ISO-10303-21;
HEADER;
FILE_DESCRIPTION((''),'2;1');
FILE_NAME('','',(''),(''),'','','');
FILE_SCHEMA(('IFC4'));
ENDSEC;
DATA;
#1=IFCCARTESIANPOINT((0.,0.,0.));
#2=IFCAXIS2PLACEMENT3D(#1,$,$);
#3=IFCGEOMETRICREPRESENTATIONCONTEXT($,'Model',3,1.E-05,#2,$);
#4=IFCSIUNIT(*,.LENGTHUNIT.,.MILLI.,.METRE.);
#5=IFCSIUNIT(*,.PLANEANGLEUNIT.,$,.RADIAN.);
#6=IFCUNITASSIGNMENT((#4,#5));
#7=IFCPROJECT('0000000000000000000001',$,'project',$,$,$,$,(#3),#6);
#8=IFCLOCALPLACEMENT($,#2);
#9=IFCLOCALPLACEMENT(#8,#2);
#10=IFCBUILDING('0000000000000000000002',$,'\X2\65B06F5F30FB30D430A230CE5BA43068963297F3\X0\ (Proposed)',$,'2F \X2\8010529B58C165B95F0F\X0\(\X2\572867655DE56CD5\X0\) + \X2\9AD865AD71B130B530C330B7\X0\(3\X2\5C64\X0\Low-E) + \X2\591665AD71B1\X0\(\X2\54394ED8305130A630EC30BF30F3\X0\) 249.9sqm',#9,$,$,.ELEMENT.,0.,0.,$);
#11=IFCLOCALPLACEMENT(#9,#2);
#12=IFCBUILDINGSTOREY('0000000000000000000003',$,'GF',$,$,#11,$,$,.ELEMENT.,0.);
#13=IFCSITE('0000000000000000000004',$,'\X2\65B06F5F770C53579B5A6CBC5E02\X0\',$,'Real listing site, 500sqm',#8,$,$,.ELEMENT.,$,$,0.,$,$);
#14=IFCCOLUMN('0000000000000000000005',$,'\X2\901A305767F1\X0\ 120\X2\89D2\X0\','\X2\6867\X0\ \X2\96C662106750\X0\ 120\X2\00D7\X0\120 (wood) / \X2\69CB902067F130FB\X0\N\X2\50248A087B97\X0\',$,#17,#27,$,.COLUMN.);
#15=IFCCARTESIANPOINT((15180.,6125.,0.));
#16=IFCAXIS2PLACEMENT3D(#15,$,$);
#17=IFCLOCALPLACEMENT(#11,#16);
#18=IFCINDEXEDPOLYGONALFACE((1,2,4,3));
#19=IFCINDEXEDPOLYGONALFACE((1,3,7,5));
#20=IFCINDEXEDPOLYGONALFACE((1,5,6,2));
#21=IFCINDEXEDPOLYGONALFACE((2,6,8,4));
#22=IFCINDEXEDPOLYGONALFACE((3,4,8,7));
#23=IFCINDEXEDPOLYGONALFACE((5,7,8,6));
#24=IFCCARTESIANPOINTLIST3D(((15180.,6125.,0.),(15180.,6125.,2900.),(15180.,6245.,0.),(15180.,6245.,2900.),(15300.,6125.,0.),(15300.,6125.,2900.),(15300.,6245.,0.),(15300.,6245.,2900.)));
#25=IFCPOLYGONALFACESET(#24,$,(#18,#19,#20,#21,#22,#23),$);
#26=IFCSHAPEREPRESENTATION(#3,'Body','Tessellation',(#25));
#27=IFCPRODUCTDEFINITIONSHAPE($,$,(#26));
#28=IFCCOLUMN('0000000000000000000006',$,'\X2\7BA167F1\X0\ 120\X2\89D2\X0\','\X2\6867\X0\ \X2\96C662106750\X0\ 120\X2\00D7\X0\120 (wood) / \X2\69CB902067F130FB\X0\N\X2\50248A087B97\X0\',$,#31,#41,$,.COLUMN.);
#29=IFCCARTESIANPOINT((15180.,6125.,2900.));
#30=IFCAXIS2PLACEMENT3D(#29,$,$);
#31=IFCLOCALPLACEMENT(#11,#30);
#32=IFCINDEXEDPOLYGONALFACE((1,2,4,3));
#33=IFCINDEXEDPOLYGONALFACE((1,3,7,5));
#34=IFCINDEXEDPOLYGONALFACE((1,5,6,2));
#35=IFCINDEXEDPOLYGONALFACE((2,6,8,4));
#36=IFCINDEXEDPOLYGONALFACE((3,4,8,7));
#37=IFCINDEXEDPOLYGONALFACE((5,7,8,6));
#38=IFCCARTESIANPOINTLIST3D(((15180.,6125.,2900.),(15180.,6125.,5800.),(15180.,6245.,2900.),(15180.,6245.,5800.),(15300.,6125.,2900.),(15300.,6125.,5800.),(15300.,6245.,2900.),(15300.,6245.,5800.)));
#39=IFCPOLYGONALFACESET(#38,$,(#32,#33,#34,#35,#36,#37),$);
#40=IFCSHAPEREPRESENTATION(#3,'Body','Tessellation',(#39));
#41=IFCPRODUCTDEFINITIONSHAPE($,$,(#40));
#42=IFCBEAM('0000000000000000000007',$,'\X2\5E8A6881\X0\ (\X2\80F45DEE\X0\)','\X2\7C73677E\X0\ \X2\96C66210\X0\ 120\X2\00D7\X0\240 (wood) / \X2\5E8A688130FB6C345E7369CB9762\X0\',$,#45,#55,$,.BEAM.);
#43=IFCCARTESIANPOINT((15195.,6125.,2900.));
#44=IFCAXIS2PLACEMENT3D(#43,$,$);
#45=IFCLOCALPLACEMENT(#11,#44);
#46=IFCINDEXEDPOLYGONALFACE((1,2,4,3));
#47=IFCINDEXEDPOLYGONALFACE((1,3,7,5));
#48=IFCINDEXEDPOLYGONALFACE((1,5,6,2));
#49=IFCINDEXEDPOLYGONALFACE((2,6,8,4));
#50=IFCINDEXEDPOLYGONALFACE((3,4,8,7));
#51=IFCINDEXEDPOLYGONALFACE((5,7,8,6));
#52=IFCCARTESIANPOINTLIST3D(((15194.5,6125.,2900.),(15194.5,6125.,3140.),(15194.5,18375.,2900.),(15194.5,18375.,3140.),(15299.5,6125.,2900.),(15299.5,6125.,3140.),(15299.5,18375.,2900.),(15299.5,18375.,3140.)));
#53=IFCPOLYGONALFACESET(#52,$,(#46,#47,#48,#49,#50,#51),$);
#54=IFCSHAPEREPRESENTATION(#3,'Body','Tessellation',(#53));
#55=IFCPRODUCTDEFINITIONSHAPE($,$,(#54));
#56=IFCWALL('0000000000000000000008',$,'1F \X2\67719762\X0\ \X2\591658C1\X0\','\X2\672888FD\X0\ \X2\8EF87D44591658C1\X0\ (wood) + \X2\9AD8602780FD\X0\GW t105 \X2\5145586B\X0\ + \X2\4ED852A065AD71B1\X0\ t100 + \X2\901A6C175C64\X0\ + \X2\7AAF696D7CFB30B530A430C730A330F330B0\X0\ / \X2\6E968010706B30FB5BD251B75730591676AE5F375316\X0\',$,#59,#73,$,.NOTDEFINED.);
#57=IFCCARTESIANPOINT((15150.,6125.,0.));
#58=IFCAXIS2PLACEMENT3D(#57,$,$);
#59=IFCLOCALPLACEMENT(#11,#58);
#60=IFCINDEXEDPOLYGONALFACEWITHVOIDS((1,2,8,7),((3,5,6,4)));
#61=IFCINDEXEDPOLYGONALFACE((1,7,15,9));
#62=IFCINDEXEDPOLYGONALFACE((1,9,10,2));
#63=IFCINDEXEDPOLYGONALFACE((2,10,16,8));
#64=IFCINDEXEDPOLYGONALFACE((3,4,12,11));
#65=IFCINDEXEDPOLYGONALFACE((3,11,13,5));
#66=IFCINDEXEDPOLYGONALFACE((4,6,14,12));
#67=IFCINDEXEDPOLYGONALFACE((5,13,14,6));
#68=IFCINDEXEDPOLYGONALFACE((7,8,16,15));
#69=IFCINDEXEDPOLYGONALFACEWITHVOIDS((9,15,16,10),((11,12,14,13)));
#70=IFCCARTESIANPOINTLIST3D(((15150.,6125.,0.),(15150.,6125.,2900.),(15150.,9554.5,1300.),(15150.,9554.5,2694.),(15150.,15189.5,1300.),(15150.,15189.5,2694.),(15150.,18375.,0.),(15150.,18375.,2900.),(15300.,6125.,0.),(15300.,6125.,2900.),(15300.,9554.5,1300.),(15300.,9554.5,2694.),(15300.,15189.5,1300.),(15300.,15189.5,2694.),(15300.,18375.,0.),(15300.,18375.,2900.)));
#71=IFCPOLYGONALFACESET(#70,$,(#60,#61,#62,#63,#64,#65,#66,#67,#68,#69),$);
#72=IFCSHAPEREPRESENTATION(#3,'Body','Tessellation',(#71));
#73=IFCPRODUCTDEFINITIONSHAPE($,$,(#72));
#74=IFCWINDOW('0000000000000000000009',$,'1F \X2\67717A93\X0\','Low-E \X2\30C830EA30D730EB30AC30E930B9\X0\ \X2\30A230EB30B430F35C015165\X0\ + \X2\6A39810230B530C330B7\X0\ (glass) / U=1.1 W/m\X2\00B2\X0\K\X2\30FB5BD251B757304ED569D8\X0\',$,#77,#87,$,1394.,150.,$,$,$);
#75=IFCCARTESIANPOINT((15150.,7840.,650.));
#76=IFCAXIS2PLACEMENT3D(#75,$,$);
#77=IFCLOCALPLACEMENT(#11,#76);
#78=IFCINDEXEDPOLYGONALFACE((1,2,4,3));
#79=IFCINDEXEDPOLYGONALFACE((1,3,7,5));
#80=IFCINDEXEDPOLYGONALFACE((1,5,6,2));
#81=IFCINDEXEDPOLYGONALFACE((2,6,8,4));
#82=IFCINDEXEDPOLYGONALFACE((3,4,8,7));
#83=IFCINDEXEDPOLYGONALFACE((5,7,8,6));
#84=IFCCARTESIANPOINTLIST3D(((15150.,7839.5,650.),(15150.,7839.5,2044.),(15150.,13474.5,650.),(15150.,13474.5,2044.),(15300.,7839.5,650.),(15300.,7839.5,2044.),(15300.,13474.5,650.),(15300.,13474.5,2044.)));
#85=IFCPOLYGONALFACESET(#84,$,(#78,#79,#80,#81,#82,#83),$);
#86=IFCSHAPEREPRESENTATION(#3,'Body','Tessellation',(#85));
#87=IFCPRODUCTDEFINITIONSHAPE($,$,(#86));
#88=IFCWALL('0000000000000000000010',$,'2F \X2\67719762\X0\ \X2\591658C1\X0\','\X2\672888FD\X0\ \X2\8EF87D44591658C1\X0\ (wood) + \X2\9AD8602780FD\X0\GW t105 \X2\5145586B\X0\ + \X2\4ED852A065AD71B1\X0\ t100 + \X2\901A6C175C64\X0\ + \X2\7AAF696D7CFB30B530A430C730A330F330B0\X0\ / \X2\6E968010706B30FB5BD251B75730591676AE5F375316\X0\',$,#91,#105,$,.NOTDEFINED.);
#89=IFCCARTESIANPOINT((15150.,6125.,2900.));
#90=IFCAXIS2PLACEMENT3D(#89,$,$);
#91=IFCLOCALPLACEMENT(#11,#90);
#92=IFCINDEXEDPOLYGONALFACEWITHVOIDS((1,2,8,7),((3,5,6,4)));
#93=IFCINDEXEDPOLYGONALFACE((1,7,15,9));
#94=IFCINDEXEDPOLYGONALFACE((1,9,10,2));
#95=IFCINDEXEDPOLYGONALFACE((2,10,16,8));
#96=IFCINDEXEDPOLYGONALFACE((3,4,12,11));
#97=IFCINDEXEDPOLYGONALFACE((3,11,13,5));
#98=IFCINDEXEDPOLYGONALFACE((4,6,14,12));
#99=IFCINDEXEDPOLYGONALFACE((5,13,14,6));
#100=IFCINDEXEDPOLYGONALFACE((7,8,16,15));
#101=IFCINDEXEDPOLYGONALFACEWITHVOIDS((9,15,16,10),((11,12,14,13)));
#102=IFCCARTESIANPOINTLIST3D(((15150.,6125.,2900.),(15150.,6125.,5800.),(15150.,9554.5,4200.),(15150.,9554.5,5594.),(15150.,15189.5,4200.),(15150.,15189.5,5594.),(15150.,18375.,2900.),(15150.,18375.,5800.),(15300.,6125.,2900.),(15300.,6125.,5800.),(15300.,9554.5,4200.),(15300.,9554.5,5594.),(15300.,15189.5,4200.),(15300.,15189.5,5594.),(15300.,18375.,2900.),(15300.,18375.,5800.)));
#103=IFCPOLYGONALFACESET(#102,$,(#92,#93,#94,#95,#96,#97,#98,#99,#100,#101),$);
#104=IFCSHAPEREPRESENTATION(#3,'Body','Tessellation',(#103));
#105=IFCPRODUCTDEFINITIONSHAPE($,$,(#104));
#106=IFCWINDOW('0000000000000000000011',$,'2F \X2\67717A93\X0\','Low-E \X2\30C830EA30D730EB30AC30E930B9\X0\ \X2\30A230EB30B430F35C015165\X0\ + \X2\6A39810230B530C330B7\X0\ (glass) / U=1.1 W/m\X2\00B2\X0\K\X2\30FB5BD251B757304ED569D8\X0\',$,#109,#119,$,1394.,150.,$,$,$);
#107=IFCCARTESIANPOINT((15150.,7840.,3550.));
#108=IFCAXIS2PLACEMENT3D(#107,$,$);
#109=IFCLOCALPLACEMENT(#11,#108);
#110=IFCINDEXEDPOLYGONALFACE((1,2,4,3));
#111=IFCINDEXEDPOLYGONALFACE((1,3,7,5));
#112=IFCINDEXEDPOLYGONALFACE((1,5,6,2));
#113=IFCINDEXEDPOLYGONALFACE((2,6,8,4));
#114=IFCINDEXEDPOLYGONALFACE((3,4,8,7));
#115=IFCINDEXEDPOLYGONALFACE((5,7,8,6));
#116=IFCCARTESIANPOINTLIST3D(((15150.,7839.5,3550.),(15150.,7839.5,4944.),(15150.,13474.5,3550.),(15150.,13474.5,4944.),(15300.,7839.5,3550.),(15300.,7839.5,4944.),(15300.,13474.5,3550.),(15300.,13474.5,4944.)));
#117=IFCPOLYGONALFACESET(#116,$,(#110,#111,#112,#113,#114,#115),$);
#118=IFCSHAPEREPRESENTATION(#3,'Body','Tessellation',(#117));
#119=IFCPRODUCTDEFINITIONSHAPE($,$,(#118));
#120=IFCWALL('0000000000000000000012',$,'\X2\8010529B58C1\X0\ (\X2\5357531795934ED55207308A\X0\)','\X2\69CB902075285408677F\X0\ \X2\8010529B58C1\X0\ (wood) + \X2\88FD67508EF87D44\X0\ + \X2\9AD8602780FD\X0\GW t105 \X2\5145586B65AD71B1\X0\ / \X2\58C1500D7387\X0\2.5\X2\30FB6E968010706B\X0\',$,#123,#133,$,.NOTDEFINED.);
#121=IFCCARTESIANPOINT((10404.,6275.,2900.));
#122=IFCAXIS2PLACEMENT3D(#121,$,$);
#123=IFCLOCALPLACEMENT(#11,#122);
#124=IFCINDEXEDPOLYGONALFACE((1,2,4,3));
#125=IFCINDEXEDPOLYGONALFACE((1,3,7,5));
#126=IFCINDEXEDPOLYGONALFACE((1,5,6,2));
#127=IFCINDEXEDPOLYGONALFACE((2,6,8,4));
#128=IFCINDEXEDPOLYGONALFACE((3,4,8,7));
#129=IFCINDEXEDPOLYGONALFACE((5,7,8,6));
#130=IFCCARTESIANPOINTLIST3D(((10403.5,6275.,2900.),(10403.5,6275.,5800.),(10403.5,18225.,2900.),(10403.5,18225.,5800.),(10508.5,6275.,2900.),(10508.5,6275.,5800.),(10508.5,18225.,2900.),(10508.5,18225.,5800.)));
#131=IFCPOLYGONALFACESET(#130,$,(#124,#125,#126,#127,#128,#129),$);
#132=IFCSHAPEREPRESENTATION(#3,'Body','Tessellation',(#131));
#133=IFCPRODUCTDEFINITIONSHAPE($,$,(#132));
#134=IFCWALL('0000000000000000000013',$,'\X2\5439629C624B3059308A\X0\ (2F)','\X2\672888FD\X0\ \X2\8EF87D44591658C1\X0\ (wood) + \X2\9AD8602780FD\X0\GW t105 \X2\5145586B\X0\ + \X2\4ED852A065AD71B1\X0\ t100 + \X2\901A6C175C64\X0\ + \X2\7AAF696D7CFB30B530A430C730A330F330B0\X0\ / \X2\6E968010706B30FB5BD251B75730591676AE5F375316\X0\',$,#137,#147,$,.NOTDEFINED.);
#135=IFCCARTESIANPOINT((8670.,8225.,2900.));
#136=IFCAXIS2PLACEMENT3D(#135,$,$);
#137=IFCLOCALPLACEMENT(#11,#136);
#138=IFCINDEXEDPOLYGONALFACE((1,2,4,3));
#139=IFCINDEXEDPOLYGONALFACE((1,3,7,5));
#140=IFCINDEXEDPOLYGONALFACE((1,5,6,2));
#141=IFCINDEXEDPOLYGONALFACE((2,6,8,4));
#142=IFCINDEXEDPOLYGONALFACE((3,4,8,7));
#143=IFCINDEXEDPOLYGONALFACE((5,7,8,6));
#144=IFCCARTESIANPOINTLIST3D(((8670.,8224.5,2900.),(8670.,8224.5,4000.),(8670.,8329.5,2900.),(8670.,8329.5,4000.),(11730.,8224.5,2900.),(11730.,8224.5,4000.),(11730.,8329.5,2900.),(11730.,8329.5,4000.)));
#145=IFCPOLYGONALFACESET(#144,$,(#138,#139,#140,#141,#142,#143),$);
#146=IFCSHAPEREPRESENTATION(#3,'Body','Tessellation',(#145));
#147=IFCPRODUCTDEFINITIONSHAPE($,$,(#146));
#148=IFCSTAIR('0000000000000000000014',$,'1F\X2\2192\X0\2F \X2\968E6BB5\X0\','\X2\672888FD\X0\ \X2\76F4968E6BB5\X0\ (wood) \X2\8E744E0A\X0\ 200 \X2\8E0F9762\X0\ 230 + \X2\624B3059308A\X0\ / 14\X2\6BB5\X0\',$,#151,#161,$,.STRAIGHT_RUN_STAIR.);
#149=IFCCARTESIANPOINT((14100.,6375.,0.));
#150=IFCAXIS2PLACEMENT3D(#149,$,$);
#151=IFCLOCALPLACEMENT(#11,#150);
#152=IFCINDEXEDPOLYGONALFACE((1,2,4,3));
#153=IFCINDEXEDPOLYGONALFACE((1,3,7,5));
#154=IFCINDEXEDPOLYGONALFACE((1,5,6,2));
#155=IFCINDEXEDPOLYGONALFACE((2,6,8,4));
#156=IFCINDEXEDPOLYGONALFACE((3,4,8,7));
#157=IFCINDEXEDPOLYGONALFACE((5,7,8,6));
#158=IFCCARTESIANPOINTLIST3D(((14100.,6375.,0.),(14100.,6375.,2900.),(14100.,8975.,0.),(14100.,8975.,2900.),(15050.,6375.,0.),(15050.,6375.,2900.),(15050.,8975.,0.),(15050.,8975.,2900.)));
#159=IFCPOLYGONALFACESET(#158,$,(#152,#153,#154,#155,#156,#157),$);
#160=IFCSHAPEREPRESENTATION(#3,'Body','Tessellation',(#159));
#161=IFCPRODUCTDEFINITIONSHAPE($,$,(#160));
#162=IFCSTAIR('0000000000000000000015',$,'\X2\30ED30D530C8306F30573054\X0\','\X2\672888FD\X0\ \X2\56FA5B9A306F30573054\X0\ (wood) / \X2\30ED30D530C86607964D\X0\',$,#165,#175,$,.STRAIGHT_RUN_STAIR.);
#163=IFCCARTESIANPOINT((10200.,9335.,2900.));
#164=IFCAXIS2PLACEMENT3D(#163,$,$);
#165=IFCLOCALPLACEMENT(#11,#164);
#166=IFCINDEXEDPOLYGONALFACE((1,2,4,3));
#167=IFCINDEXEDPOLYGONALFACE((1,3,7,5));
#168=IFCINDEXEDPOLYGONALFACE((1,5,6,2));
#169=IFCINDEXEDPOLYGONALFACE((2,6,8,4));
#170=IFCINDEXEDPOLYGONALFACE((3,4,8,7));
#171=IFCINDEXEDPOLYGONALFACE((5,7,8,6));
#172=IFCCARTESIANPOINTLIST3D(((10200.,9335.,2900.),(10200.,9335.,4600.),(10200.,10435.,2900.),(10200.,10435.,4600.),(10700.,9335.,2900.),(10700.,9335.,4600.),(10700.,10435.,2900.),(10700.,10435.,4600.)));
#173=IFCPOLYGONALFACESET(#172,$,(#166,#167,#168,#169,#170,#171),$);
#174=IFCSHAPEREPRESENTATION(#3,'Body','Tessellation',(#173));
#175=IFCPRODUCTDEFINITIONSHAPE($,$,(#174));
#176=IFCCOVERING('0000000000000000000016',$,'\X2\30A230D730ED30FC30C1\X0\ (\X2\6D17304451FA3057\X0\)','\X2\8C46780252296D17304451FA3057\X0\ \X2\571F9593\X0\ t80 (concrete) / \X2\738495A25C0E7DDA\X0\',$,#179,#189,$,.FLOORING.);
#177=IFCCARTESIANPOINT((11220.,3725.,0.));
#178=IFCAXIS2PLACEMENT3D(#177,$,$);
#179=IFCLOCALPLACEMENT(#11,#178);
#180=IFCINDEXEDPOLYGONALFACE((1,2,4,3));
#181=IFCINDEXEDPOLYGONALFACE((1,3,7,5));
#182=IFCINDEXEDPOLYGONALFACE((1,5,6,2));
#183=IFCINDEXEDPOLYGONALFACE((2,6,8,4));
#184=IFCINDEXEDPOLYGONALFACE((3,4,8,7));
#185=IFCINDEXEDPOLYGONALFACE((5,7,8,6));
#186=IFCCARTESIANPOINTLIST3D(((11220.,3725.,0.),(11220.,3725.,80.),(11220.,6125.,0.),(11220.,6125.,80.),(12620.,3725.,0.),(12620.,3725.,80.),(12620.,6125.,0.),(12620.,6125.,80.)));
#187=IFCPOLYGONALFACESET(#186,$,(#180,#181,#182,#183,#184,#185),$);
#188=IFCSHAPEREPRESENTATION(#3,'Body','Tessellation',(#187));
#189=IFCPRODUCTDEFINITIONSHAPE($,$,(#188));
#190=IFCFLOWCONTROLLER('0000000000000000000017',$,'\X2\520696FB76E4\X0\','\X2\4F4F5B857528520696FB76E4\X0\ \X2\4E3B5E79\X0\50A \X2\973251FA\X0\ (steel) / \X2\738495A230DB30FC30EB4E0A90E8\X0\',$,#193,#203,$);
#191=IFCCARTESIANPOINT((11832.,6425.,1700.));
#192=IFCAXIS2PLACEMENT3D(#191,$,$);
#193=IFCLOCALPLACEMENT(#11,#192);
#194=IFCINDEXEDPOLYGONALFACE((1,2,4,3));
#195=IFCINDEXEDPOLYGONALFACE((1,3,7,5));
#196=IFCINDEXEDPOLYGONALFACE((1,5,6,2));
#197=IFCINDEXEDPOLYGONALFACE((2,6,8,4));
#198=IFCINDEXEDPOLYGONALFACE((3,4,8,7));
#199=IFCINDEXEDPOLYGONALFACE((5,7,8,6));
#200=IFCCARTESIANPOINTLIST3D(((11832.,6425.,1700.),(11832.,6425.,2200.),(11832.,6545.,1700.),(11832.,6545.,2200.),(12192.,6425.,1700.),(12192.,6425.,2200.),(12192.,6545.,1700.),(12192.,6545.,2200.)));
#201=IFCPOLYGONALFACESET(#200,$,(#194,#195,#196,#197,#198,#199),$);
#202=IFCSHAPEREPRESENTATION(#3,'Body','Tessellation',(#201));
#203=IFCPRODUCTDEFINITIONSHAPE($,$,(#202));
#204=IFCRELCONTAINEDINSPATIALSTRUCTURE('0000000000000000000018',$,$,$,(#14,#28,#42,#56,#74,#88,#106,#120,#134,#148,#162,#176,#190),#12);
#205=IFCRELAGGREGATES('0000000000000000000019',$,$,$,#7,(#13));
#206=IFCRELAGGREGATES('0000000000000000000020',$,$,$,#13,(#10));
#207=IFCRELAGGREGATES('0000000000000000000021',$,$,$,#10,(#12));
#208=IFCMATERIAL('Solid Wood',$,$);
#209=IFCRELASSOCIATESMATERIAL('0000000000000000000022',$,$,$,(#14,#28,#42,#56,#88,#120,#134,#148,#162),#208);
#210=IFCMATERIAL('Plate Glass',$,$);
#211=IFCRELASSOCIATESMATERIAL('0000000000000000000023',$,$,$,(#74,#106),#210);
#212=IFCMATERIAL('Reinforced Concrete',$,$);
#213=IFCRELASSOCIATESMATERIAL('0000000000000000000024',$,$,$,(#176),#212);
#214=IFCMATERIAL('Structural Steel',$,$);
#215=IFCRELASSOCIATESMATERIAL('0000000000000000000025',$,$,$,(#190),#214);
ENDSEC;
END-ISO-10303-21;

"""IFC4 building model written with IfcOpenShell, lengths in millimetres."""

from ifc_helpers import new_model, si_unit, frame, frame_2d, origin, place, context, project, spatial, rectangle, extrude, material, element, fill, save


model = new_model("IFC4")

# Units and contexts
model_context = context("Model", 3, precision=1e-05, world=origin())
ifc_project = project(units=[si_unit("LENGTHUNIT", "METRE", prefix="MILLI"), si_unit("PLANEANGLEUNIT", "RADIAN")], contexts=[model_context])

# Site, building, storey
site_placement = place(None, origin())
site = spatial("IfcSite", under=ifc_project, at=site_placement, Name="新潟県南魚沼市", ObjectType="Real listing site, 500sqm", CompositionType="ELEMENT", RefElevation=0.0)
building_placement = place(site_placement, origin())
building = spatial("IfcBuilding", under=site, at=building_placement, Name="新潟・ピアノ室と防音 (Proposed)", ObjectType="2F 耐力壁方式(在来工法) + 高断熱サッシ(3層Low-E) + 外断熱(吹付けウレタン) 249.9sqm", CompositionType="ELEMENT", ElevationOfRefHeight=0.0, ElevationOfTerrain=0.0)
storey_placement = place(building_placement, origin())
storey = spatial("IfcBuildingStorey", under=building, at=storey_placement, Name="GF", CompositionType="ELEMENT", Elevation=0.0)

# Columns
ifc_material_1 = material(Name="Solid Wood")
column_1_placement = place(storey_placement, frame((15180.0, 6125.0, 0.0)))
element("IfcColumn", 1, at=column_1_placement, inside=storey, material=ifc_material_1, Name="通し柱 120角", Description="桧 集成材 120×120 (wood) / 構造柱・N値計算", PredefinedType="COLUMN", context=model_context, shape_type="SweptSolid", body=[
    extrude(rectangle(XDim=120.0, YDim=120.0, at=frame_2d((60.0, 60.0))), frame((15180.0, 6125.0, 0.0)), (0.0, 0.0, 1.0), 2900.0),
])
column_2_placement = place(storey_placement, frame((15180.0, 6125.0, 2900.0)))
element("IfcColumn", 2, at=column_2_placement, inside=storey, material=ifc_material_1, Name="管柱 120角", Description="桧 集成材 120×120 (wood) / 構造柱・N値計算", PredefinedType="COLUMN", context=model_context, shape_type="SweptSolid", body=[
    extrude(rectangle(XDim=120.0, YDim=120.0, at=frame_2d((60.0, 60.0))), frame((15180.0, 6125.0, 2900.0)), (0.0, 0.0, 1.0), 2900.0),
])

# Beam
beam_1_placement = place(storey_placement, frame((15195.0, 6125.0, 2900.0)))
element("IfcBeam", 3, at=beam_1_placement, inside=storey, material=ifc_material_1, Name="床梁 (胴差)", Description="米松 集成 120×240 (wood) / 床梁・水平構面", PredefinedType="BEAM", context=model_context, shape_type="SweptSolid", body=[
    extrude(rectangle(XDim=105.0, YDim=12250.0, at=frame_2d((52.0, 6125.0))), frame((15195.0, 6125.0, 2900.0)), (0.0, 0.0, 1.0), 240.0),
])

# Wall, opening, window
wall_1_placement = place(storey_placement, frame((15150.0, 6125.0, 0.0)))
wall_1 = element("IfcWall", 4, at=wall_1_placement, inside=storey, material=ifc_material_1, Name="1F 東面 外壁", Description="木製 軸組外壁 (wood) + 高性能GW t105 充填 + 付加断熱 t100 + 通気層 + 窯業系サイディング / 準耐火・寒冷地外皮強化", PredefinedType="NOTDEFINED", context=model_context, shape_type="SweptSolid", body=[
    extrude(rectangle(XDim=150.0, YDim=12250.0, at=frame_2d((75.0, 6125.0))), frame((15150.0, 6125.0, 0.0)), (0.0, 0.0, 1.0), 2900.0),
])
opening_1_placement = place(storey_placement, frame((15150.0, 7840.0, 650.0)))
opening_1 = element("IfcOpeningElement", 5, at=opening_1_placement, cuts=wall_1, PredefinedType="NOTDEFINED", context=model_context, shape_type="SweptSolid", body=[
    extrude(rectangle(XDim=150.0, YDim=5635.0, at=frame_2d((75.0, 2817.0))), frame((15150.0, 7840.0, 650.0)), (0.0, 0.0, 1.0), 1394.0),
])
ifc_material_2 = material(Name="Plate Glass")
window_1_placement = place(storey_placement, frame((15150.0, 7840.0, 650.0)))
window_1 = element("IfcWindow", 6, at=window_1_placement, inside=storey, material=ifc_material_2, Name="1F 東窓", Description="Low-E トリプルガラス アルゴン封入 + 樹脂サッシ (glass) / U=1.1 W/m²K・寒冷地仕様", OverallHeight=1394.0, OverallWidth=150.0, context=model_context, shape_type="SweptSolid", body=[
    extrude(rectangle(XDim=150.0, YDim=5635.0, at=frame_2d((75.0, 2817.0))), frame((15150.0, 7840.0, 650.0)), (0.0, 0.0, 1.0), 1394.0),
])
fill(opening_1, window_1)

# Wall, opening, window
wall_2_placement = place(storey_placement, frame((15150.0, 6125.0, 2900.0)))
wall_2 = element("IfcWall", 7, at=wall_2_placement, inside=storey, material=ifc_material_1, Name="2F 東面 外壁", Description="木製 軸組外壁 (wood) + 高性能GW t105 充填 + 付加断熱 t100 + 通気層 + 窯業系サイディング / 準耐火・寒冷地外皮強化", PredefinedType="NOTDEFINED", context=model_context, shape_type="SweptSolid", body=[
    extrude(rectangle(XDim=150.0, YDim=12250.0, at=frame_2d((75.0, 6125.0))), frame((15150.0, 6125.0, 2900.0)), (0.0, 0.0, 1.0), 2900.0),
])
opening_2_placement = place(storey_placement, frame((15150.0, 7840.0, 3550.0)))
opening_2 = element("IfcOpeningElement", 8, at=opening_2_placement, cuts=wall_2, PredefinedType="NOTDEFINED", context=model_context, shape_type="SweptSolid", body=[
    extrude(rectangle(XDim=150.0, YDim=5635.0, at=frame_2d((75.0, 2817.0))), frame((15150.0, 7840.0, 3550.0)), (0.0, 0.0, 1.0), 1394.0),
])
window_2_placement = place(storey_placement, frame((15150.0, 7840.0, 3550.0)))
window_2 = element("IfcWindow", 9, at=window_2_placement, inside=storey, material=ifc_material_2, Name="2F 東窓", Description="Low-E トリプルガラス アルゴン封入 + 樹脂サッシ (glass) / U=1.1 W/m²K・寒冷地仕様", OverallHeight=1394.0, OverallWidth=150.0, context=model_context, shape_type="SweptSolid", body=[
    extrude(rectangle(XDim=150.0, YDim=5635.0, at=frame_2d((75.0, 2817.0))), frame((15150.0, 7840.0, 3550.0)), (0.0, 0.0, 1.0), 1394.0),
])
fill(opening_2, window_2)

# Walls
wall_3_placement = place(storey_placement, frame((10404.0, 6275.0, 2900.0)))
element("IfcWall", 10, at=wall_3_placement, inside=storey, material=ifc_material_1, Name="耐力壁 (南北間仕切り)", Description="構造用合板 耐力壁 (wood) + 製材軸組 + 高性能GW t105 充填断熱 / 壁倍率2.5・準耐火", PredefinedType="NOTDEFINED", context=model_context, shape_type="SweptSolid", body=[
    extrude(rectangle(XDim=105.0, YDim=11950.0, at=frame_2d((52.0, 5975.0))), frame((10404.0, 6275.0, 2900.0)), (0.0, 0.0, 1.0), 2900.0),
])
wall_4_placement = place(storey_placement, frame((8670.0, 8225.0, 2900.0)))
element("IfcWall", 11, at=wall_4_placement, inside=storey, material=ifc_material_1, Name="吹抜手すり (2F)", Description="木製 軸組外壁 (wood) + 高性能GW t105 充填 + 付加断熱 t100 + 通気層 + 窯業系サイディング / 準耐火・寒冷地外皮強化", PredefinedType="NOTDEFINED", context=model_context, shape_type="SweptSolid", body=[
    extrude(rectangle(XDim=3060.0, YDim=105.0, at=frame_2d((1530.0, 52.0))), frame((8670.0, 8225.0, 2900.0)), (0.0, 0.0, 1.0), 1100.0),
])

# Stairs
stair_1_placement = place(storey_placement, frame((14100.0, 6375.0, 0.0)))
element("IfcStair", 12, at=stair_1_placement, inside=storey, material=ifc_material_1, Name="1F→2F 階段", Description="木製 直階段 (wood) 蹴上 200 踏面 230 + 手すり / 14段", PredefinedType="STRAIGHT_RUN_STAIR", context=model_context, shape_type="SweptSolid", body=[
    extrude(rectangle(XDim=950.0, YDim=2600.0, at=frame_2d((475.0, 1300.0))), frame((14100.0, 6375.0, 0.0)), (0.0, 0.0, 1.0), 2900.0),
])
stair_2_placement = place(storey_placement, frame((10200.0, 9335.0, 2900.0)))
element("IfcStair", 13, at=stair_2_placement, inside=storey, material=ifc_material_1, Name="ロフトはしご", Description="木製 固定はしご (wood) / ロフト昇降", PredefinedType="STRAIGHT_RUN_STAIR", context=model_context, shape_type="SweptSolid", body=[
    extrude(rectangle(XDim=500.0, YDim=1100.0, at=frame_2d((250.0, 550.0))), frame((10200.0, 9335.0, 2900.0)), (0.0, 0.0, 1.0), 1700.0),
])

# Covering
ifc_material_3 = material(Name="Reinforced Concrete")
covering_placement = place(storey_placement, frame((11220.0, 3725.0, 0.0)))
element("IfcCovering", 14, at=covering_placement, inside=storey, material=ifc_material_3, Name="アプローチ (洗い出し)", Description="豆砂利洗い出し 土間 t80 (concrete) / 玄関導線", PredefinedType="FLOORING", context=model_context, shape_type="SweptSolid", body=[
    extrude(rectangle(XDim=1400.0, YDim=2400.0, at=frame_2d((700.0, 1200.0))), frame((11220.0, 3725.0, 0.0)), (0.0, 0.0, 1.0), 80.0),
])

# Flow controller
ifc_material_4 = material(Name="Structural Steel")
flow_controller_placement = place(storey_placement, frame((11832.0, 6425.0, 1700.0)))
element("IfcFlowController", 15, at=flow_controller_placement, inside=storey, material=ifc_material_4, Name="分電盤", Description="住宅用分電盤 主幹50A 露出 (steel) / 玄関ホール上部", context=model_context, shape_type="SweptSolid", body=[
    extrude(rectangle(XDim=360.0, YDim=120.0, at=frame_2d((180.0, 60.0))), frame((11832.0, 6425.0, 1700.0)), (0.0, 0.0, 1.0), 500.0),
])

save(model, "model.ifc")
